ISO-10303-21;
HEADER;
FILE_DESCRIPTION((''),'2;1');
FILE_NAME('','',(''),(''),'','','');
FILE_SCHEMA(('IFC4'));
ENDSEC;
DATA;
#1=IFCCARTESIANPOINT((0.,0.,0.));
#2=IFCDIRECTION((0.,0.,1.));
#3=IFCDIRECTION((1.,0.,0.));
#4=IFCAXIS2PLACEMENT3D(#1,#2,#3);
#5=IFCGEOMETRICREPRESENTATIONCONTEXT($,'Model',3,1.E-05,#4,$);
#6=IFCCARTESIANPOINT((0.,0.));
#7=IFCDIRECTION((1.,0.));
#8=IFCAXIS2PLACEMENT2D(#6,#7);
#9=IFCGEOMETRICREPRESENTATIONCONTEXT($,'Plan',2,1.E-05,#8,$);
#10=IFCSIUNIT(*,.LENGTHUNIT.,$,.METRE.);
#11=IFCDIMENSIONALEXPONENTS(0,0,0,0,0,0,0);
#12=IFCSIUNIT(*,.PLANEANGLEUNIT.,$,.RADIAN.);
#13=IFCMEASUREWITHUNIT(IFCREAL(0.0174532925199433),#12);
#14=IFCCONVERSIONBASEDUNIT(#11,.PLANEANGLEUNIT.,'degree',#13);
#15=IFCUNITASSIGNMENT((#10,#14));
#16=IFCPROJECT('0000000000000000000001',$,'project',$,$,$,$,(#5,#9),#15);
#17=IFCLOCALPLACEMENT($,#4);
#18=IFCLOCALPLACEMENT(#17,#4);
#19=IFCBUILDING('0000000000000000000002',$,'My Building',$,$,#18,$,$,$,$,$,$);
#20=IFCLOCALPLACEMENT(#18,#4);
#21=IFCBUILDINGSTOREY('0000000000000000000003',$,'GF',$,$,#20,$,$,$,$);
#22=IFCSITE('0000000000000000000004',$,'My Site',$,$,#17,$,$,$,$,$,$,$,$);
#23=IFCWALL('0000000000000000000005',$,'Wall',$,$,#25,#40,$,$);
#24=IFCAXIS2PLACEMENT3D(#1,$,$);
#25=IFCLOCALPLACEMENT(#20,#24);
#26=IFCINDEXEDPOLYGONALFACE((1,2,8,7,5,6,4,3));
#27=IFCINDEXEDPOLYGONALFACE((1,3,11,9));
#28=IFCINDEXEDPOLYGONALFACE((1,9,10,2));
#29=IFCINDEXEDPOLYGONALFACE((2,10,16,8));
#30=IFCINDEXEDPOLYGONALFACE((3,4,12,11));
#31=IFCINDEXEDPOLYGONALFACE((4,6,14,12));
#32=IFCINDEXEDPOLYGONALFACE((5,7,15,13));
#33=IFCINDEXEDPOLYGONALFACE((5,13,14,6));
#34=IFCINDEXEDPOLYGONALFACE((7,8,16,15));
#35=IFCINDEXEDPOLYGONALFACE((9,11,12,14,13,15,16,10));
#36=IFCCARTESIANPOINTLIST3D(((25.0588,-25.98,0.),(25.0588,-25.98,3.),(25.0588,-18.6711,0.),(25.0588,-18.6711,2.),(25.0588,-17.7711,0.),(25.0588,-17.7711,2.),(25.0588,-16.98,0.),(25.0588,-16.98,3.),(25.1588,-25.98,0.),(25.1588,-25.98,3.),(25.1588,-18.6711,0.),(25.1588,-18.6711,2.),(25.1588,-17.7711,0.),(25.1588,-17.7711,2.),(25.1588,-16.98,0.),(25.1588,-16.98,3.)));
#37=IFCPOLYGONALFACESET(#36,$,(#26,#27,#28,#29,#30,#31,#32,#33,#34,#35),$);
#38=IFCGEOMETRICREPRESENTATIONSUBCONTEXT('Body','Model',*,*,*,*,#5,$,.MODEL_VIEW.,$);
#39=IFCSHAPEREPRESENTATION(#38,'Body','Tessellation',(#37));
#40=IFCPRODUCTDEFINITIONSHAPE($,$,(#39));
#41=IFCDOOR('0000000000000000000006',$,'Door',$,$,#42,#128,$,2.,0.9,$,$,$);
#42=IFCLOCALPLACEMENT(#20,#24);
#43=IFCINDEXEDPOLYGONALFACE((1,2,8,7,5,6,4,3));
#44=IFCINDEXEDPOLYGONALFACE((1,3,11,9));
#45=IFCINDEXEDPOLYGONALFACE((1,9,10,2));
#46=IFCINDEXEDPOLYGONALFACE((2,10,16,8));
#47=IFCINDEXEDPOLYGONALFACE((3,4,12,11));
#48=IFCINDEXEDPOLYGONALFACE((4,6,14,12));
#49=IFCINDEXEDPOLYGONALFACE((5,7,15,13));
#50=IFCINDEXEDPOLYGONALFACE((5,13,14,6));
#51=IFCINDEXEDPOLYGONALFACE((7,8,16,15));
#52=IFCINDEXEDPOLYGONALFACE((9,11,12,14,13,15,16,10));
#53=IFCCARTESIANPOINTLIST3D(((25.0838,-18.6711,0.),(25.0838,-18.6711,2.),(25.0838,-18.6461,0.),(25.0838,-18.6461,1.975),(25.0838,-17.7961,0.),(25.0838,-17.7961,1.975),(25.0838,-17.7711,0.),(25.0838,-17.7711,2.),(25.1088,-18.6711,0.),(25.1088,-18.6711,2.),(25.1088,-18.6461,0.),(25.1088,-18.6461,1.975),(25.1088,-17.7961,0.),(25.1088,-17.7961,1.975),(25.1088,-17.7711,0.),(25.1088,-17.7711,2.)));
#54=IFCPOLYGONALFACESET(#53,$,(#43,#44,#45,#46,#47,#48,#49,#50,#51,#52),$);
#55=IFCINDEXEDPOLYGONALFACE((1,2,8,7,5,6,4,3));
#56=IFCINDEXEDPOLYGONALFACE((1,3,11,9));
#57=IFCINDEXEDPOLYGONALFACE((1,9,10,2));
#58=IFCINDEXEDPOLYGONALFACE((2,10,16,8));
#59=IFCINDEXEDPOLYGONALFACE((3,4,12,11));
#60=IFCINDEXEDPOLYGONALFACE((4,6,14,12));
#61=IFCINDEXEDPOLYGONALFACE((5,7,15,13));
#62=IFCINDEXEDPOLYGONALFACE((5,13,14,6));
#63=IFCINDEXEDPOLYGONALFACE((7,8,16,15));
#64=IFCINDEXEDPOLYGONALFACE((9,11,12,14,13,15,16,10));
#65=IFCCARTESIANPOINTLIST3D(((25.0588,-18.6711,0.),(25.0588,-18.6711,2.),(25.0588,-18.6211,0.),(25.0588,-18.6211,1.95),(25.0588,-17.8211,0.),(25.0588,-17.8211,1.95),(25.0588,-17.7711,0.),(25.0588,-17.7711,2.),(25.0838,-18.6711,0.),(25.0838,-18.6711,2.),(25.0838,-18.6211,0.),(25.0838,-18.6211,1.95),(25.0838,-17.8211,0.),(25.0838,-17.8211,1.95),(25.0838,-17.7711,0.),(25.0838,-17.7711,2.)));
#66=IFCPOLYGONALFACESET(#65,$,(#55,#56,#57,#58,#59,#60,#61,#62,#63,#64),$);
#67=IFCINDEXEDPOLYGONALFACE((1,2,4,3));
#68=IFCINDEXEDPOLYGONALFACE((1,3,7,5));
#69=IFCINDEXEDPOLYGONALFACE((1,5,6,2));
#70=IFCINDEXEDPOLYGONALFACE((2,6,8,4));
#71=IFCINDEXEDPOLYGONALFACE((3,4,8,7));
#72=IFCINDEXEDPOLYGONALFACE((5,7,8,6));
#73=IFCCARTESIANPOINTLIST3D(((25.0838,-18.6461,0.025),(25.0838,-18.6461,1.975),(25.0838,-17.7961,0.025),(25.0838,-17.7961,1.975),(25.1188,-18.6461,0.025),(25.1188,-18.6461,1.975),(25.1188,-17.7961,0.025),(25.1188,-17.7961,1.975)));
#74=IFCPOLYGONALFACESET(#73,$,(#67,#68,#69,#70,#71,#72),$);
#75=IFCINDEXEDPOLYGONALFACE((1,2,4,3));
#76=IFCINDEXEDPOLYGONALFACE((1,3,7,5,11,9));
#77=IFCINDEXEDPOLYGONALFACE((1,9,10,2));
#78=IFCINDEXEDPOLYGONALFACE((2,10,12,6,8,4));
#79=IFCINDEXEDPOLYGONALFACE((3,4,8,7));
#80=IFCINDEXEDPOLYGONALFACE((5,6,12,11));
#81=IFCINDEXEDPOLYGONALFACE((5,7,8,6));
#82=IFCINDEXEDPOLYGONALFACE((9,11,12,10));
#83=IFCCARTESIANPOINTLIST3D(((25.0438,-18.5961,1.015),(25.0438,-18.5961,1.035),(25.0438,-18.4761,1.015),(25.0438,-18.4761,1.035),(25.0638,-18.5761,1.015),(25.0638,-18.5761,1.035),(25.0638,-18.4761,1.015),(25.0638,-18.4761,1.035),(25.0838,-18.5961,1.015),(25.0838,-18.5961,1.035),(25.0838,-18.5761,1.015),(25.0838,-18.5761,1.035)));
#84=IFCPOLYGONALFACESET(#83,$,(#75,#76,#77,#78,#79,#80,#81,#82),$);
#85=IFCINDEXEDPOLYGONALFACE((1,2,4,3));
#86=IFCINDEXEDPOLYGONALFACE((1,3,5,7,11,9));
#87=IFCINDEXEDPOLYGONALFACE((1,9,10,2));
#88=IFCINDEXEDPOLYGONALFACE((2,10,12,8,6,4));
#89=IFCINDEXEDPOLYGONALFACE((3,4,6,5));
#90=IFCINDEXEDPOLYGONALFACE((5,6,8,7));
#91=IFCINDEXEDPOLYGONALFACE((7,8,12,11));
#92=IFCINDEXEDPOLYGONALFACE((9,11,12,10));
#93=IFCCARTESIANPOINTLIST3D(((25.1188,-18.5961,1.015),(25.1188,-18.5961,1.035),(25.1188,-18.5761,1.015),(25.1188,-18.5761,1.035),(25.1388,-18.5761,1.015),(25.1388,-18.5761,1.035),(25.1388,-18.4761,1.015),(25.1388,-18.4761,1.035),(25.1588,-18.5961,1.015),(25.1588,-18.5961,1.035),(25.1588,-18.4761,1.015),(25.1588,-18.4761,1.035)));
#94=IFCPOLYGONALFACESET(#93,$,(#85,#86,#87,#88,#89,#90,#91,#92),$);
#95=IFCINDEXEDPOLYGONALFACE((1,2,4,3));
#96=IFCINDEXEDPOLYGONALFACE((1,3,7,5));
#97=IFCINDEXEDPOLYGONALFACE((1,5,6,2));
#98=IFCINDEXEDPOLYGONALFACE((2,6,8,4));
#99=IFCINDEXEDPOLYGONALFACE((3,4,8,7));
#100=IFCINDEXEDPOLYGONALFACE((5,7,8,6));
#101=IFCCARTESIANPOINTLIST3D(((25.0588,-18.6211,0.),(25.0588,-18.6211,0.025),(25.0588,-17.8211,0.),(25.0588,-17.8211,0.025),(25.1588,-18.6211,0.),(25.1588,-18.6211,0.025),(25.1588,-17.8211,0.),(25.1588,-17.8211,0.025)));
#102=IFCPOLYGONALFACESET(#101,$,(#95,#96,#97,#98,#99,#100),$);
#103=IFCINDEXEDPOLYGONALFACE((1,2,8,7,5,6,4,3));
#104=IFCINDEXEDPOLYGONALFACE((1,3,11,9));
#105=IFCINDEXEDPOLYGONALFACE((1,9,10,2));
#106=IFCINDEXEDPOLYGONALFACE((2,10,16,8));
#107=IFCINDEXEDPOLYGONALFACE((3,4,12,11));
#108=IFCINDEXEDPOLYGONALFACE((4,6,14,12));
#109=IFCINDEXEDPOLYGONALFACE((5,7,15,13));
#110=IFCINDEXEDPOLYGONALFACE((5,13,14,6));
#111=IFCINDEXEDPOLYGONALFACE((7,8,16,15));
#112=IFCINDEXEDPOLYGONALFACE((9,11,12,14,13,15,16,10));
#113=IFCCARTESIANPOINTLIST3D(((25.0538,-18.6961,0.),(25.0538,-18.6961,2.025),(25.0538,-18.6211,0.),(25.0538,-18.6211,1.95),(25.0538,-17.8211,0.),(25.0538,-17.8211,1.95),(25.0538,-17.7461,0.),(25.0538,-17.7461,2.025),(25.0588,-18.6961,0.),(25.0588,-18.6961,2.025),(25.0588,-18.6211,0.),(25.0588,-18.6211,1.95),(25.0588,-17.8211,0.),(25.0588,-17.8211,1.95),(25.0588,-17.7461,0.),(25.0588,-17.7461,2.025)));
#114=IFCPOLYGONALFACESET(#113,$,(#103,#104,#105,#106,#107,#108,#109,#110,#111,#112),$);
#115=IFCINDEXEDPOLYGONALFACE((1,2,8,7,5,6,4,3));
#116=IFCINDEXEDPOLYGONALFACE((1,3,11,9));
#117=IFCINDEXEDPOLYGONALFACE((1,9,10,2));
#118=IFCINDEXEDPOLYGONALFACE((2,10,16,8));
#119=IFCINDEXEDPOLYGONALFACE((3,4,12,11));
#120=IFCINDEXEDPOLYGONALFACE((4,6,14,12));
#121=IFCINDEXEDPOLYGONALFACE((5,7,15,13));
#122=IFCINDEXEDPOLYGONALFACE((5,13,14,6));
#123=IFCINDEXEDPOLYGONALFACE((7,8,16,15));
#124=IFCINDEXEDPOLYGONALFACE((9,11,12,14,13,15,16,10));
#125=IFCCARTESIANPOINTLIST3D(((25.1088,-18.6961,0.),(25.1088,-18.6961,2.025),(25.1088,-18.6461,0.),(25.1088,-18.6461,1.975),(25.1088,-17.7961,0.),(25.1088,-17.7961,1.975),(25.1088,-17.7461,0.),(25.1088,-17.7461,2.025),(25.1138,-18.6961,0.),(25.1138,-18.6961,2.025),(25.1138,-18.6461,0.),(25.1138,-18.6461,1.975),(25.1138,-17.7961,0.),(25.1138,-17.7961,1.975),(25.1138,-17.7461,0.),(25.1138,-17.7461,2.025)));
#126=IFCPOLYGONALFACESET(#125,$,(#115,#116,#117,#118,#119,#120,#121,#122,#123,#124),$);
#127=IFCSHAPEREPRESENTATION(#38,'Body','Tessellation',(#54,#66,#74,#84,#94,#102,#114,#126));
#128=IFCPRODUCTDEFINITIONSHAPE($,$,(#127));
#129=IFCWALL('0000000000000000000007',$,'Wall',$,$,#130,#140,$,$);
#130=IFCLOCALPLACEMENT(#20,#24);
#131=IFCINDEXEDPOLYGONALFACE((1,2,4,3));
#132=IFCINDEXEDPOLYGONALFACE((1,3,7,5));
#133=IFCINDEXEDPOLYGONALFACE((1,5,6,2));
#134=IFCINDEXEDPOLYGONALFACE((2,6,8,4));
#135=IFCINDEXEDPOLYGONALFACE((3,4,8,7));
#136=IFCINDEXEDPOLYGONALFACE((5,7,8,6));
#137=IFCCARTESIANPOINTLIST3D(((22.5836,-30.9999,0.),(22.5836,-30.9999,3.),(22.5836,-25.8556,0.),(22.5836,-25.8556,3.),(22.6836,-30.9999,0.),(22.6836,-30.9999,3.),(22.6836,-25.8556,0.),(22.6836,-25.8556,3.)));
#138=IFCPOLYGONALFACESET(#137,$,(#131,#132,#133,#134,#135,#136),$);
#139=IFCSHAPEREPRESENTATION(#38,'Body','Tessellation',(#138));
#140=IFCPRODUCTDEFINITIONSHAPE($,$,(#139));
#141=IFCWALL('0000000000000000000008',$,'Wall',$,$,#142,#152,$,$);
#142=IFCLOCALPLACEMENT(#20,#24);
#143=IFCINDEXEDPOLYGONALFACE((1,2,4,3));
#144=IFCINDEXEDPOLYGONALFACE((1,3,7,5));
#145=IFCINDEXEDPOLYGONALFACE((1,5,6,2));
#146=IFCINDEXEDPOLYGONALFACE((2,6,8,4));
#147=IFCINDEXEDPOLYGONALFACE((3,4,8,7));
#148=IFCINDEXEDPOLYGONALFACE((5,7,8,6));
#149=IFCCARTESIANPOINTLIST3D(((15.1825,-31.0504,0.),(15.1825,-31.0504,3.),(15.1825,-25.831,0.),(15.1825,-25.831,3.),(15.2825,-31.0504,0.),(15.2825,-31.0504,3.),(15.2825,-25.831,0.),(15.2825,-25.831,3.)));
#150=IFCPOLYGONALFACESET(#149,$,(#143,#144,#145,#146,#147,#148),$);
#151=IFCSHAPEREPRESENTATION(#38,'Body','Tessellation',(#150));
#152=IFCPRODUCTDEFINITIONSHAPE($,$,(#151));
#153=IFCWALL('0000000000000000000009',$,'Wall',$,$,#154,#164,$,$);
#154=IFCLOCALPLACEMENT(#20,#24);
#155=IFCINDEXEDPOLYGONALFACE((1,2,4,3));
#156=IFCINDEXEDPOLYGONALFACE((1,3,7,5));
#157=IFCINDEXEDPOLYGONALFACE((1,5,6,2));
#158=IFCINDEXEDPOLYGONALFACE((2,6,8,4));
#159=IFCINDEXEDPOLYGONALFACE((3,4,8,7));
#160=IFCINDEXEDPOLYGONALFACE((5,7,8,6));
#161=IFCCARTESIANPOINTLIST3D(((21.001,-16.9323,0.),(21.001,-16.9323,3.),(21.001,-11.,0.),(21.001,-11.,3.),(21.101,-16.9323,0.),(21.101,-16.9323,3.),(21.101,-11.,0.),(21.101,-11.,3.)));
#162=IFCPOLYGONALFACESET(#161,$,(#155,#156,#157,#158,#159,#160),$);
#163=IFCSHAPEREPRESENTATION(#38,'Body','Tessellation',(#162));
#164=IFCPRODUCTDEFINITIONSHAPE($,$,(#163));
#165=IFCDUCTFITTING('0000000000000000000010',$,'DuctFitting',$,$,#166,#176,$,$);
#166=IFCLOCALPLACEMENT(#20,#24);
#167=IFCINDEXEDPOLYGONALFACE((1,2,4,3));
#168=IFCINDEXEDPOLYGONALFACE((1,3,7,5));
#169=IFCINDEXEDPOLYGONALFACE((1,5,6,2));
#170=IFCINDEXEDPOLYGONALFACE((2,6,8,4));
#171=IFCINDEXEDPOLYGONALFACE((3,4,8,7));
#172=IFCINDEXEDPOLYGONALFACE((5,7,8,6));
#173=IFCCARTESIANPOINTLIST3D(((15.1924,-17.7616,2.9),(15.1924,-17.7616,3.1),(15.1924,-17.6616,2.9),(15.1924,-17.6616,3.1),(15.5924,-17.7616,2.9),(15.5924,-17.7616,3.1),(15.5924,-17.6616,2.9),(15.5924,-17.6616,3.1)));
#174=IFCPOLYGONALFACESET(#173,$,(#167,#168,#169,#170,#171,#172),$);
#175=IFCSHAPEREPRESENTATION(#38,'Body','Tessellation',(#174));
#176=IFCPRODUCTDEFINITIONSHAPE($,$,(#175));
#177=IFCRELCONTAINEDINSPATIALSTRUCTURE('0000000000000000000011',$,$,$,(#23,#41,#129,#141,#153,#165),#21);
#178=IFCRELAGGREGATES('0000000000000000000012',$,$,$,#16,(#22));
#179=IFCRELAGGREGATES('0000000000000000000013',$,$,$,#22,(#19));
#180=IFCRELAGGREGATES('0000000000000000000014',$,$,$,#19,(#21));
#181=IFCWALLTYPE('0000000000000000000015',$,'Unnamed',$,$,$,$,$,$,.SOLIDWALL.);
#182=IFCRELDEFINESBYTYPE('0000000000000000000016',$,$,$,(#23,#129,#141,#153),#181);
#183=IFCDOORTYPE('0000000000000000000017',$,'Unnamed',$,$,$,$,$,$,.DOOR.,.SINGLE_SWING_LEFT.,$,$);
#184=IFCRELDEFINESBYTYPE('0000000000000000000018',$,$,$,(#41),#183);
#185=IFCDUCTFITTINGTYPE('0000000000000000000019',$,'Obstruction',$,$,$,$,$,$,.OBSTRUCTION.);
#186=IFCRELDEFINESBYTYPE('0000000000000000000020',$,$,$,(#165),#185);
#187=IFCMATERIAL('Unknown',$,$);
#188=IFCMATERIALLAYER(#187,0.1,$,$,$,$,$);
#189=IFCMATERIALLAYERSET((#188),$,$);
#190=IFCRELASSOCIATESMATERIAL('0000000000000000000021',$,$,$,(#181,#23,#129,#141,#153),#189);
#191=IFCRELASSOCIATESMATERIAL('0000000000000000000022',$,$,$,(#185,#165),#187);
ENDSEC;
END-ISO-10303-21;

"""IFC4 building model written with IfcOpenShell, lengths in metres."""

from ifc_helpers import new_model, entity, si_unit, converted_unit, frame, origin_with_axes, origin_2d_with_axis, place, context, subcontext, project, spatial, line, indexed_curve, rectangle, outline, extrude, shape, source, transform, mapped, material, layer, layer_set, layer_usage, material_profile, profile_set, profile_usage, type_object, type_shapes, element, fill, save


model = new_model("IFC4")

# Units and contexts
model_context = context("Model", 3, precision=1e-05, world=origin_with_axes())
plan_context = context("Plan", 2, precision=1e-05, world=origin_2d_with_axis())
body_context_1 = subcontext(model_context, "Body", "Model", "MODEL_VIEW")
body_context_2 = subcontext(plan_context, "Body", "Plan", "PLAN_VIEW")
ifc_project = project(units=[si_unit("LENGTHUNIT", "METRE"), converted_unit("PLANEANGLEUNIT", "degree", entity("IfcReal", 0.0174532925199433), si_unit("PLANEANGLEUNIT", "RADIAN"), dimensions=[0, 0, 0, 0, 0, 0, 0])], contexts=[model_context, plan_context])

# Site, building, storey
site_placement = place(None, origin_with_axes())
site = spatial("IfcSite", under=ifc_project, at=site_placement, Name="My Site")
building_placement = place(site_placement, origin_with_axes())
building = spatial("IfcBuilding", under=site, at=building_placement, Name="My Building")
storey_placement = place(building_placement, origin_with_axes())
storey = spatial("IfcBuildingStorey", under=building, at=storey_placement, Name="GF")

# Shared definitions
ifc_material = material(Name="Unknown")
ifc_layer = layer(ifc_material, 0.1)
ifc_layer_set = layer_set([ifc_layer])
wall_type = type_object("IfcWallType", Name="Unnamed", PredefinedType="SOLIDWALL", material=ifc_layer_set)

# Shared definitions
shared_shape_1 = source(origin_with_axes(), body_context_1, "Body", "SweptSolid", [
    extrude(outline(indexed_curve([(0.0, 0.0), (0.9, 0.0), (0.9, 2.0), (0.0, 2.0)], segments=[line(1, 2, 3, 4, 1)])), frame((0.0, -0.6, 0.0), z_axis=(0.0, -1.0, 0.0), x_axis=(1.0, 0.0, 0.0)), (0.0, 0.0, -1.0), 1.2),
])
door_type = type_object("IfcDoorType", Name="Unnamed", OperationType="SINGLE_SWING_LEFT", PredefinedType="DOOR")
shared_shape_2 = source(origin_with_axes(), body_context_1, "Body", "SweptSolid", [
    extrude(outline(indexed_curve([(0.0, 0.0), (0.0, 2.0), (0.9, 2.0), (0.9, 0.0), (0.875, 0.0), (0.875, 1.975), (0.025, 1.975), (0.025, 0.0)], segments=[line(1, 2, 3, 4, 5, 6, 7, 8, 1)])), frame((0.0, 0.025, 0.0), z_axis=(0.0, -1.0, 0.0), x_axis=(1.0, 0.0, 0.0)), (0.0, 0.0, -1.0), 0.025),
    extrude(outline(indexed_curve([(0.0, 0.0), (0.0, 2.0), (0.9, 2.0), (0.9, 0.0), (0.85, 0.0), (0.85, 1.95), (0.05, 1.95), (0.05, 0.0)], segments=[line(1, 2, 3, 4, 5, 6, 7, 8, 1)])), frame((0.0, 0.0, 0.0), z_axis=(0.0, -1.0, 0.0), x_axis=(1.0, 0.0, 0.0)), (0.0, 0.0, -1.0), 0.025),
    extrude(outline(indexed_curve([(0.0, 0.0), (0.85, 0.0), (0.85, 0.035), (0.0, 0.035)], segments=[line(1, 2, 3, 4, 1)])), frame((0.025, 0.025, 0.025), z_axis=(0.0, 0.0, 1.0), x_axis=(1.0, 0.0, 0.0)), (0.0, 0.0, 1.0), 1.95),
    extrude(outline(indexed_curve([(0.0, 0.0), (0.0, -0.04), (-0.12, -0.04), (-0.12, -0.02), (-0.02, -0.02), (-0.02, 0.0)], segments=[line(1, 2, 3, 4, 5, 6, 1)])), frame((0.825, 0.025, 1.015), z_axis=(0.0, 0.0, 1.0), x_axis=(1.0, 0.0, 0.0)), (0.0, 0.0, 1.0), 0.02),
    extrude(outline(indexed_curve([(0.0, 0.0), (0.0, 0.04), (-0.12, 0.04), (-0.12, 0.02), (-0.02, 0.02), (-0.02, 0.0)], segments=[line(1, 2, 3, 4, 5, 6, 1)])), frame((0.825, 0.06, 1.015), z_axis=(0.0, 0.0, 1.0), x_axis=(1.0, 0.0, 0.0)), (0.0, 0.0, 1.0), 0.02),
    extrude(outline(indexed_curve([(0.0, 0.0), (0.8, 0.0), (0.8, 0.1), (0.0, 0.1)], segments=[line(1, 2, 3, 4, 1)])), frame((0.05, 0.0, 0.0), z_axis=(0.0, 0.0, 1.0), x_axis=(1.0, 0.0, 0.0)), (0.0, 0.0, 1.0), 0.025),
    extrude(outline(indexed_curve([(0.0, 0.0), (0.0, 2.025), (0.95, 2.025), (0.95, 0.0), (0.875, 0.0), (0.875, 1.95), (0.075, 1.95), (0.075, 0.0)], segments=[line(1, 2, 3, 4, 5, 6, 7, 8, 1)])), frame((-0.025, -0.005, 0.0), z_axis=(0.0, -1.0, 0.0), x_axis=(1.0, 0.0, 0.0)), (0.0, 0.0, -1.0), 0.005),
    extrude(outline(indexed_curve([(0.0, 0.0), (0.0, 2.025), (0.95, 2.025), (0.95, 0.0), (0.9, 0.0), (0.9, 1.975), (0.05, 1.975), (0.05, 0.0)], segments=[line(1, 2, 3, 4, 5, 6, 7, 8, 1)])), frame((-0.025, 0.05, 0.0), z_axis=(0.0, -1.0, 0.0), x_axis=(1.0, 0.0, 0.0)), (0.0, 0.0, -1.0), 0.005),
])
shared_shape_3 = source(origin_with_axes(), body_context_2, "Body", "Curve2D", [
    entity("IfcIndexedPolyCurve", entity("IfcCartesianPointList2D", [[0.0, 0.0], [0.0, 0.05], [0.025, 0.05], [0.025, 0.025], [0.05, 0.025], [0.05, 0.0]]), [entity("IfcLineIndex", [1, 2, 3, 4, 5, 6, 1])]),
    entity("IfcIndexedPolyCurve", entity("IfcCartesianPointList2D", [[0.9, 0.0], [0.9, 0.05], [0.875, 0.05], [0.875, 0.025], [0.85, 0.025], [0.85, 0.0]]), [entity("IfcLineIndex", [1, 2, 3, 4, 5, 6, 1])]),
    entity("IfcTrimmedCurve", entity("IfcEllipse", entity("IfcAxis2Placement2D", entity("IfcCartesianPoint", [0.06, 0.05]), entity("IfcDirection", [1.0, 0.0])), 0.815, 0.85), [entity("IfcCartesianPoint", [0.875, 0.05])], [entity("IfcCartesianPoint", [0.06, 0.9])], True, "CARTESIAN"),
    entity("IfcIndexedPolyCurve", entity("IfcCartesianPointList2D", [[0.025, 0.05], [0.06, 0.05], [0.06, 0.9], [0.025, 0.9]]), [entity("IfcLineIndex", [1, 2, 3, 4, 1])]),
])
type_shapes(door_type, [shared_shape_2, shared_shape_3])

# Wall, opening, door
ifc_layer_usage_1 = layer_usage(ifc_layer_set, "AXIS2", "POSITIVE", 0.0)
wall_1_placement = place(storey_placement, frame((25.0588, -16.98, 0.0), z_axis=(0.0, 0.0, 1.0), x_axis=(0.0, -1.0, 0.0)))
wall_1 = element("IfcWall", 1, at=wall_1_placement, inside=storey, type_object=wall_type, material=ifc_layer_usage_1, Name="Wall", context=body_context_1, shape_type="SweptSolid", body=[
    extrude(outline(indexed_curve([(0.0, 0.0), (0.0, 0.1), (9.0, 0.1), (9.0, 0.0)], segments=[line(1, 2, 3, 4, 1)])), origin_with_axes(), (0.0, 0.0, 1.0), 3.0),
])
opening_1_placement = place(wall_1_placement, frame((0.7911, 0.0, 0.0), z_axis=(0.0, 0.0, 1.0), x_axis=(1.0, 0.0, 0.0)))
opening_1 = element("IfcOpeningElement", 2, at=opening_1_placement, cuts=wall_1, PredefinedType="OPENING", context=body_context_1, shape_type="MappedRepresentation", body=[
    mapped(shared_shape_1, transform((0.0, 0.0, 0.0), x_axis=(1.0, 0.0, 0.0), y_axis=(0.0, 1.0, 0.0), z_axis=(0.0, 0.0, 1.0), scale=1.0)),
])
door_1_placement = place(opening_1_placement, frame((0.0, 0.0, 0.0), z_axis=(0.0, 0.0, 1.0), x_axis=(1.0, 0.0, 0.0)))
door_1 = element("IfcDoor", 3, at=door_1_placement, inside=storey, type_object=door_type, Name="Door", OverallHeight=2.0, OverallWidth=0.9, shapes=[
    shape(body_context_1, "Body", "MappedRepresentation", [mapped(shared_shape_2, transform((0.0, 0.0, 0.0), x_axis=(1.0, 0.0, 0.0), y_axis=(0.0, 1.0, 0.0), z_axis=(0.0, 0.0, 1.0), scale=1.0))]),
    shape(body_context_2, "Body", "MappedRepresentation", [mapped(shared_shape_3, transform((0.0, 0.0, 0.0), x_axis=(1.0, 0.0, 0.0), y_axis=(0.0, 1.0, 0.0), z_axis=(0.0, 0.0, 1.0), scale=1.0))]),
])
fill(opening_1, door_1)

# Walls
ifc_layer_usage_2 = layer_usage(ifc_layer_set, "AXIS2", "POSITIVE", 0.0)
wall_2_placement = place(storey_placement, frame((22.5836, -25.8556, 0.0), z_axis=(0.0, 0.0, 1.0), x_axis=(0.0, -1.0, 0.0)))
element("IfcWall", 4, at=wall_2_placement, inside=storey, type_object=wall_type, material=ifc_layer_usage_2, Name="Wall", context=body_context_1, shape_type="SweptSolid", body=[
    extrude(outline(indexed_curve([(0.0, 0.0), (0.0, 0.1), (5.1443, 0.1), (5.1443, 0.0)], segments=[line(1, 2, 3, 4, 1)])), origin_with_axes(), (0.0, 0.0, 1.0), 3.0),
])
ifc_layer_usage_3 = layer_usage(ifc_layer_set, "AXIS2", "POSITIVE", 0.0)
wall_3_placement = place(storey_placement, frame((15.1825, -25.831, 0.0), z_axis=(0.0, 0.0, 1.0), x_axis=(0.0, -1.0, 0.0)))
element("IfcWall", 5, at=wall_3_placement, inside=storey, type_object=wall_type, material=ifc_layer_usage_3, Name="Wall", context=body_context_1, shape_type="SweptSolid", body=[
    extrude(outline(indexed_curve([(0.0, 0.0), (0.0, 0.1), (5.2194, 0.1), (5.2194, 0.0)], segments=[line(1, 2, 3, 4, 1)])), origin_with_axes(), (0.0, 0.0, 1.0), 3.0),
])
ifc_layer_usage_4 = layer_usage(ifc_layer_set, "AXIS2", "POSITIVE", 0.0)
wall_4_placement = place(storey_placement, frame((21.101, -16.9323, 0.0), z_axis=(0.0, 0.0, 1.0), x_axis=(0.0, 1.0, 0.0)))
element("IfcWall", 6, at=wall_4_placement, inside=storey, type_object=wall_type, material=ifc_layer_usage_4, Name="Wall", context=body_context_1, shape_type="SweptSolid", body=[
    extrude(outline(indexed_curve([(0.0, 0.0), (0.0, 0.1), (5.9323, 0.1), (5.9323, 0.0)], segments=[line(1, 2, 3, 4, 1)])), origin_with_axes(), (0.0, 0.0, 1.0), 3.0),
])

# Duct fitting
ifc_material_profile = material_profile(ifc_material, rectangle(XDim=0.4, YDim=0.2))
ifc_profile_set = profile_set([ifc_material_profile])
ifc_profile_usage_1 = profile_usage(ifc_profile_set, cardinal=5)
duct_fitting_type = type_object("IfcDuctFittingType", Name="Obstruction", PredefinedType="OBSTRUCTION", material=ifc_profile_set)
duct_fitting_1_placement = place(storey_placement, frame((15.3924, -17.7616, 3.0), z_axis=(0.0, 1.0, 0.0), x_axis=(-1.0, 0.0, 0.0)))
element("IfcDuctFitting", 7, at=duct_fitting_1_placement, inside=storey, type_object=duct_fitting_type, material=ifc_profile_usage_1, Name="DuctFitting", context=body_context_1, shape_type="SweptSolid", body=[
    extrude(rectangle(XDim=0.4, YDim=0.2), origin_with_axes(), (0.0, 0.0, 1.0), 0.1),
])

save(model, "model.ifc")
